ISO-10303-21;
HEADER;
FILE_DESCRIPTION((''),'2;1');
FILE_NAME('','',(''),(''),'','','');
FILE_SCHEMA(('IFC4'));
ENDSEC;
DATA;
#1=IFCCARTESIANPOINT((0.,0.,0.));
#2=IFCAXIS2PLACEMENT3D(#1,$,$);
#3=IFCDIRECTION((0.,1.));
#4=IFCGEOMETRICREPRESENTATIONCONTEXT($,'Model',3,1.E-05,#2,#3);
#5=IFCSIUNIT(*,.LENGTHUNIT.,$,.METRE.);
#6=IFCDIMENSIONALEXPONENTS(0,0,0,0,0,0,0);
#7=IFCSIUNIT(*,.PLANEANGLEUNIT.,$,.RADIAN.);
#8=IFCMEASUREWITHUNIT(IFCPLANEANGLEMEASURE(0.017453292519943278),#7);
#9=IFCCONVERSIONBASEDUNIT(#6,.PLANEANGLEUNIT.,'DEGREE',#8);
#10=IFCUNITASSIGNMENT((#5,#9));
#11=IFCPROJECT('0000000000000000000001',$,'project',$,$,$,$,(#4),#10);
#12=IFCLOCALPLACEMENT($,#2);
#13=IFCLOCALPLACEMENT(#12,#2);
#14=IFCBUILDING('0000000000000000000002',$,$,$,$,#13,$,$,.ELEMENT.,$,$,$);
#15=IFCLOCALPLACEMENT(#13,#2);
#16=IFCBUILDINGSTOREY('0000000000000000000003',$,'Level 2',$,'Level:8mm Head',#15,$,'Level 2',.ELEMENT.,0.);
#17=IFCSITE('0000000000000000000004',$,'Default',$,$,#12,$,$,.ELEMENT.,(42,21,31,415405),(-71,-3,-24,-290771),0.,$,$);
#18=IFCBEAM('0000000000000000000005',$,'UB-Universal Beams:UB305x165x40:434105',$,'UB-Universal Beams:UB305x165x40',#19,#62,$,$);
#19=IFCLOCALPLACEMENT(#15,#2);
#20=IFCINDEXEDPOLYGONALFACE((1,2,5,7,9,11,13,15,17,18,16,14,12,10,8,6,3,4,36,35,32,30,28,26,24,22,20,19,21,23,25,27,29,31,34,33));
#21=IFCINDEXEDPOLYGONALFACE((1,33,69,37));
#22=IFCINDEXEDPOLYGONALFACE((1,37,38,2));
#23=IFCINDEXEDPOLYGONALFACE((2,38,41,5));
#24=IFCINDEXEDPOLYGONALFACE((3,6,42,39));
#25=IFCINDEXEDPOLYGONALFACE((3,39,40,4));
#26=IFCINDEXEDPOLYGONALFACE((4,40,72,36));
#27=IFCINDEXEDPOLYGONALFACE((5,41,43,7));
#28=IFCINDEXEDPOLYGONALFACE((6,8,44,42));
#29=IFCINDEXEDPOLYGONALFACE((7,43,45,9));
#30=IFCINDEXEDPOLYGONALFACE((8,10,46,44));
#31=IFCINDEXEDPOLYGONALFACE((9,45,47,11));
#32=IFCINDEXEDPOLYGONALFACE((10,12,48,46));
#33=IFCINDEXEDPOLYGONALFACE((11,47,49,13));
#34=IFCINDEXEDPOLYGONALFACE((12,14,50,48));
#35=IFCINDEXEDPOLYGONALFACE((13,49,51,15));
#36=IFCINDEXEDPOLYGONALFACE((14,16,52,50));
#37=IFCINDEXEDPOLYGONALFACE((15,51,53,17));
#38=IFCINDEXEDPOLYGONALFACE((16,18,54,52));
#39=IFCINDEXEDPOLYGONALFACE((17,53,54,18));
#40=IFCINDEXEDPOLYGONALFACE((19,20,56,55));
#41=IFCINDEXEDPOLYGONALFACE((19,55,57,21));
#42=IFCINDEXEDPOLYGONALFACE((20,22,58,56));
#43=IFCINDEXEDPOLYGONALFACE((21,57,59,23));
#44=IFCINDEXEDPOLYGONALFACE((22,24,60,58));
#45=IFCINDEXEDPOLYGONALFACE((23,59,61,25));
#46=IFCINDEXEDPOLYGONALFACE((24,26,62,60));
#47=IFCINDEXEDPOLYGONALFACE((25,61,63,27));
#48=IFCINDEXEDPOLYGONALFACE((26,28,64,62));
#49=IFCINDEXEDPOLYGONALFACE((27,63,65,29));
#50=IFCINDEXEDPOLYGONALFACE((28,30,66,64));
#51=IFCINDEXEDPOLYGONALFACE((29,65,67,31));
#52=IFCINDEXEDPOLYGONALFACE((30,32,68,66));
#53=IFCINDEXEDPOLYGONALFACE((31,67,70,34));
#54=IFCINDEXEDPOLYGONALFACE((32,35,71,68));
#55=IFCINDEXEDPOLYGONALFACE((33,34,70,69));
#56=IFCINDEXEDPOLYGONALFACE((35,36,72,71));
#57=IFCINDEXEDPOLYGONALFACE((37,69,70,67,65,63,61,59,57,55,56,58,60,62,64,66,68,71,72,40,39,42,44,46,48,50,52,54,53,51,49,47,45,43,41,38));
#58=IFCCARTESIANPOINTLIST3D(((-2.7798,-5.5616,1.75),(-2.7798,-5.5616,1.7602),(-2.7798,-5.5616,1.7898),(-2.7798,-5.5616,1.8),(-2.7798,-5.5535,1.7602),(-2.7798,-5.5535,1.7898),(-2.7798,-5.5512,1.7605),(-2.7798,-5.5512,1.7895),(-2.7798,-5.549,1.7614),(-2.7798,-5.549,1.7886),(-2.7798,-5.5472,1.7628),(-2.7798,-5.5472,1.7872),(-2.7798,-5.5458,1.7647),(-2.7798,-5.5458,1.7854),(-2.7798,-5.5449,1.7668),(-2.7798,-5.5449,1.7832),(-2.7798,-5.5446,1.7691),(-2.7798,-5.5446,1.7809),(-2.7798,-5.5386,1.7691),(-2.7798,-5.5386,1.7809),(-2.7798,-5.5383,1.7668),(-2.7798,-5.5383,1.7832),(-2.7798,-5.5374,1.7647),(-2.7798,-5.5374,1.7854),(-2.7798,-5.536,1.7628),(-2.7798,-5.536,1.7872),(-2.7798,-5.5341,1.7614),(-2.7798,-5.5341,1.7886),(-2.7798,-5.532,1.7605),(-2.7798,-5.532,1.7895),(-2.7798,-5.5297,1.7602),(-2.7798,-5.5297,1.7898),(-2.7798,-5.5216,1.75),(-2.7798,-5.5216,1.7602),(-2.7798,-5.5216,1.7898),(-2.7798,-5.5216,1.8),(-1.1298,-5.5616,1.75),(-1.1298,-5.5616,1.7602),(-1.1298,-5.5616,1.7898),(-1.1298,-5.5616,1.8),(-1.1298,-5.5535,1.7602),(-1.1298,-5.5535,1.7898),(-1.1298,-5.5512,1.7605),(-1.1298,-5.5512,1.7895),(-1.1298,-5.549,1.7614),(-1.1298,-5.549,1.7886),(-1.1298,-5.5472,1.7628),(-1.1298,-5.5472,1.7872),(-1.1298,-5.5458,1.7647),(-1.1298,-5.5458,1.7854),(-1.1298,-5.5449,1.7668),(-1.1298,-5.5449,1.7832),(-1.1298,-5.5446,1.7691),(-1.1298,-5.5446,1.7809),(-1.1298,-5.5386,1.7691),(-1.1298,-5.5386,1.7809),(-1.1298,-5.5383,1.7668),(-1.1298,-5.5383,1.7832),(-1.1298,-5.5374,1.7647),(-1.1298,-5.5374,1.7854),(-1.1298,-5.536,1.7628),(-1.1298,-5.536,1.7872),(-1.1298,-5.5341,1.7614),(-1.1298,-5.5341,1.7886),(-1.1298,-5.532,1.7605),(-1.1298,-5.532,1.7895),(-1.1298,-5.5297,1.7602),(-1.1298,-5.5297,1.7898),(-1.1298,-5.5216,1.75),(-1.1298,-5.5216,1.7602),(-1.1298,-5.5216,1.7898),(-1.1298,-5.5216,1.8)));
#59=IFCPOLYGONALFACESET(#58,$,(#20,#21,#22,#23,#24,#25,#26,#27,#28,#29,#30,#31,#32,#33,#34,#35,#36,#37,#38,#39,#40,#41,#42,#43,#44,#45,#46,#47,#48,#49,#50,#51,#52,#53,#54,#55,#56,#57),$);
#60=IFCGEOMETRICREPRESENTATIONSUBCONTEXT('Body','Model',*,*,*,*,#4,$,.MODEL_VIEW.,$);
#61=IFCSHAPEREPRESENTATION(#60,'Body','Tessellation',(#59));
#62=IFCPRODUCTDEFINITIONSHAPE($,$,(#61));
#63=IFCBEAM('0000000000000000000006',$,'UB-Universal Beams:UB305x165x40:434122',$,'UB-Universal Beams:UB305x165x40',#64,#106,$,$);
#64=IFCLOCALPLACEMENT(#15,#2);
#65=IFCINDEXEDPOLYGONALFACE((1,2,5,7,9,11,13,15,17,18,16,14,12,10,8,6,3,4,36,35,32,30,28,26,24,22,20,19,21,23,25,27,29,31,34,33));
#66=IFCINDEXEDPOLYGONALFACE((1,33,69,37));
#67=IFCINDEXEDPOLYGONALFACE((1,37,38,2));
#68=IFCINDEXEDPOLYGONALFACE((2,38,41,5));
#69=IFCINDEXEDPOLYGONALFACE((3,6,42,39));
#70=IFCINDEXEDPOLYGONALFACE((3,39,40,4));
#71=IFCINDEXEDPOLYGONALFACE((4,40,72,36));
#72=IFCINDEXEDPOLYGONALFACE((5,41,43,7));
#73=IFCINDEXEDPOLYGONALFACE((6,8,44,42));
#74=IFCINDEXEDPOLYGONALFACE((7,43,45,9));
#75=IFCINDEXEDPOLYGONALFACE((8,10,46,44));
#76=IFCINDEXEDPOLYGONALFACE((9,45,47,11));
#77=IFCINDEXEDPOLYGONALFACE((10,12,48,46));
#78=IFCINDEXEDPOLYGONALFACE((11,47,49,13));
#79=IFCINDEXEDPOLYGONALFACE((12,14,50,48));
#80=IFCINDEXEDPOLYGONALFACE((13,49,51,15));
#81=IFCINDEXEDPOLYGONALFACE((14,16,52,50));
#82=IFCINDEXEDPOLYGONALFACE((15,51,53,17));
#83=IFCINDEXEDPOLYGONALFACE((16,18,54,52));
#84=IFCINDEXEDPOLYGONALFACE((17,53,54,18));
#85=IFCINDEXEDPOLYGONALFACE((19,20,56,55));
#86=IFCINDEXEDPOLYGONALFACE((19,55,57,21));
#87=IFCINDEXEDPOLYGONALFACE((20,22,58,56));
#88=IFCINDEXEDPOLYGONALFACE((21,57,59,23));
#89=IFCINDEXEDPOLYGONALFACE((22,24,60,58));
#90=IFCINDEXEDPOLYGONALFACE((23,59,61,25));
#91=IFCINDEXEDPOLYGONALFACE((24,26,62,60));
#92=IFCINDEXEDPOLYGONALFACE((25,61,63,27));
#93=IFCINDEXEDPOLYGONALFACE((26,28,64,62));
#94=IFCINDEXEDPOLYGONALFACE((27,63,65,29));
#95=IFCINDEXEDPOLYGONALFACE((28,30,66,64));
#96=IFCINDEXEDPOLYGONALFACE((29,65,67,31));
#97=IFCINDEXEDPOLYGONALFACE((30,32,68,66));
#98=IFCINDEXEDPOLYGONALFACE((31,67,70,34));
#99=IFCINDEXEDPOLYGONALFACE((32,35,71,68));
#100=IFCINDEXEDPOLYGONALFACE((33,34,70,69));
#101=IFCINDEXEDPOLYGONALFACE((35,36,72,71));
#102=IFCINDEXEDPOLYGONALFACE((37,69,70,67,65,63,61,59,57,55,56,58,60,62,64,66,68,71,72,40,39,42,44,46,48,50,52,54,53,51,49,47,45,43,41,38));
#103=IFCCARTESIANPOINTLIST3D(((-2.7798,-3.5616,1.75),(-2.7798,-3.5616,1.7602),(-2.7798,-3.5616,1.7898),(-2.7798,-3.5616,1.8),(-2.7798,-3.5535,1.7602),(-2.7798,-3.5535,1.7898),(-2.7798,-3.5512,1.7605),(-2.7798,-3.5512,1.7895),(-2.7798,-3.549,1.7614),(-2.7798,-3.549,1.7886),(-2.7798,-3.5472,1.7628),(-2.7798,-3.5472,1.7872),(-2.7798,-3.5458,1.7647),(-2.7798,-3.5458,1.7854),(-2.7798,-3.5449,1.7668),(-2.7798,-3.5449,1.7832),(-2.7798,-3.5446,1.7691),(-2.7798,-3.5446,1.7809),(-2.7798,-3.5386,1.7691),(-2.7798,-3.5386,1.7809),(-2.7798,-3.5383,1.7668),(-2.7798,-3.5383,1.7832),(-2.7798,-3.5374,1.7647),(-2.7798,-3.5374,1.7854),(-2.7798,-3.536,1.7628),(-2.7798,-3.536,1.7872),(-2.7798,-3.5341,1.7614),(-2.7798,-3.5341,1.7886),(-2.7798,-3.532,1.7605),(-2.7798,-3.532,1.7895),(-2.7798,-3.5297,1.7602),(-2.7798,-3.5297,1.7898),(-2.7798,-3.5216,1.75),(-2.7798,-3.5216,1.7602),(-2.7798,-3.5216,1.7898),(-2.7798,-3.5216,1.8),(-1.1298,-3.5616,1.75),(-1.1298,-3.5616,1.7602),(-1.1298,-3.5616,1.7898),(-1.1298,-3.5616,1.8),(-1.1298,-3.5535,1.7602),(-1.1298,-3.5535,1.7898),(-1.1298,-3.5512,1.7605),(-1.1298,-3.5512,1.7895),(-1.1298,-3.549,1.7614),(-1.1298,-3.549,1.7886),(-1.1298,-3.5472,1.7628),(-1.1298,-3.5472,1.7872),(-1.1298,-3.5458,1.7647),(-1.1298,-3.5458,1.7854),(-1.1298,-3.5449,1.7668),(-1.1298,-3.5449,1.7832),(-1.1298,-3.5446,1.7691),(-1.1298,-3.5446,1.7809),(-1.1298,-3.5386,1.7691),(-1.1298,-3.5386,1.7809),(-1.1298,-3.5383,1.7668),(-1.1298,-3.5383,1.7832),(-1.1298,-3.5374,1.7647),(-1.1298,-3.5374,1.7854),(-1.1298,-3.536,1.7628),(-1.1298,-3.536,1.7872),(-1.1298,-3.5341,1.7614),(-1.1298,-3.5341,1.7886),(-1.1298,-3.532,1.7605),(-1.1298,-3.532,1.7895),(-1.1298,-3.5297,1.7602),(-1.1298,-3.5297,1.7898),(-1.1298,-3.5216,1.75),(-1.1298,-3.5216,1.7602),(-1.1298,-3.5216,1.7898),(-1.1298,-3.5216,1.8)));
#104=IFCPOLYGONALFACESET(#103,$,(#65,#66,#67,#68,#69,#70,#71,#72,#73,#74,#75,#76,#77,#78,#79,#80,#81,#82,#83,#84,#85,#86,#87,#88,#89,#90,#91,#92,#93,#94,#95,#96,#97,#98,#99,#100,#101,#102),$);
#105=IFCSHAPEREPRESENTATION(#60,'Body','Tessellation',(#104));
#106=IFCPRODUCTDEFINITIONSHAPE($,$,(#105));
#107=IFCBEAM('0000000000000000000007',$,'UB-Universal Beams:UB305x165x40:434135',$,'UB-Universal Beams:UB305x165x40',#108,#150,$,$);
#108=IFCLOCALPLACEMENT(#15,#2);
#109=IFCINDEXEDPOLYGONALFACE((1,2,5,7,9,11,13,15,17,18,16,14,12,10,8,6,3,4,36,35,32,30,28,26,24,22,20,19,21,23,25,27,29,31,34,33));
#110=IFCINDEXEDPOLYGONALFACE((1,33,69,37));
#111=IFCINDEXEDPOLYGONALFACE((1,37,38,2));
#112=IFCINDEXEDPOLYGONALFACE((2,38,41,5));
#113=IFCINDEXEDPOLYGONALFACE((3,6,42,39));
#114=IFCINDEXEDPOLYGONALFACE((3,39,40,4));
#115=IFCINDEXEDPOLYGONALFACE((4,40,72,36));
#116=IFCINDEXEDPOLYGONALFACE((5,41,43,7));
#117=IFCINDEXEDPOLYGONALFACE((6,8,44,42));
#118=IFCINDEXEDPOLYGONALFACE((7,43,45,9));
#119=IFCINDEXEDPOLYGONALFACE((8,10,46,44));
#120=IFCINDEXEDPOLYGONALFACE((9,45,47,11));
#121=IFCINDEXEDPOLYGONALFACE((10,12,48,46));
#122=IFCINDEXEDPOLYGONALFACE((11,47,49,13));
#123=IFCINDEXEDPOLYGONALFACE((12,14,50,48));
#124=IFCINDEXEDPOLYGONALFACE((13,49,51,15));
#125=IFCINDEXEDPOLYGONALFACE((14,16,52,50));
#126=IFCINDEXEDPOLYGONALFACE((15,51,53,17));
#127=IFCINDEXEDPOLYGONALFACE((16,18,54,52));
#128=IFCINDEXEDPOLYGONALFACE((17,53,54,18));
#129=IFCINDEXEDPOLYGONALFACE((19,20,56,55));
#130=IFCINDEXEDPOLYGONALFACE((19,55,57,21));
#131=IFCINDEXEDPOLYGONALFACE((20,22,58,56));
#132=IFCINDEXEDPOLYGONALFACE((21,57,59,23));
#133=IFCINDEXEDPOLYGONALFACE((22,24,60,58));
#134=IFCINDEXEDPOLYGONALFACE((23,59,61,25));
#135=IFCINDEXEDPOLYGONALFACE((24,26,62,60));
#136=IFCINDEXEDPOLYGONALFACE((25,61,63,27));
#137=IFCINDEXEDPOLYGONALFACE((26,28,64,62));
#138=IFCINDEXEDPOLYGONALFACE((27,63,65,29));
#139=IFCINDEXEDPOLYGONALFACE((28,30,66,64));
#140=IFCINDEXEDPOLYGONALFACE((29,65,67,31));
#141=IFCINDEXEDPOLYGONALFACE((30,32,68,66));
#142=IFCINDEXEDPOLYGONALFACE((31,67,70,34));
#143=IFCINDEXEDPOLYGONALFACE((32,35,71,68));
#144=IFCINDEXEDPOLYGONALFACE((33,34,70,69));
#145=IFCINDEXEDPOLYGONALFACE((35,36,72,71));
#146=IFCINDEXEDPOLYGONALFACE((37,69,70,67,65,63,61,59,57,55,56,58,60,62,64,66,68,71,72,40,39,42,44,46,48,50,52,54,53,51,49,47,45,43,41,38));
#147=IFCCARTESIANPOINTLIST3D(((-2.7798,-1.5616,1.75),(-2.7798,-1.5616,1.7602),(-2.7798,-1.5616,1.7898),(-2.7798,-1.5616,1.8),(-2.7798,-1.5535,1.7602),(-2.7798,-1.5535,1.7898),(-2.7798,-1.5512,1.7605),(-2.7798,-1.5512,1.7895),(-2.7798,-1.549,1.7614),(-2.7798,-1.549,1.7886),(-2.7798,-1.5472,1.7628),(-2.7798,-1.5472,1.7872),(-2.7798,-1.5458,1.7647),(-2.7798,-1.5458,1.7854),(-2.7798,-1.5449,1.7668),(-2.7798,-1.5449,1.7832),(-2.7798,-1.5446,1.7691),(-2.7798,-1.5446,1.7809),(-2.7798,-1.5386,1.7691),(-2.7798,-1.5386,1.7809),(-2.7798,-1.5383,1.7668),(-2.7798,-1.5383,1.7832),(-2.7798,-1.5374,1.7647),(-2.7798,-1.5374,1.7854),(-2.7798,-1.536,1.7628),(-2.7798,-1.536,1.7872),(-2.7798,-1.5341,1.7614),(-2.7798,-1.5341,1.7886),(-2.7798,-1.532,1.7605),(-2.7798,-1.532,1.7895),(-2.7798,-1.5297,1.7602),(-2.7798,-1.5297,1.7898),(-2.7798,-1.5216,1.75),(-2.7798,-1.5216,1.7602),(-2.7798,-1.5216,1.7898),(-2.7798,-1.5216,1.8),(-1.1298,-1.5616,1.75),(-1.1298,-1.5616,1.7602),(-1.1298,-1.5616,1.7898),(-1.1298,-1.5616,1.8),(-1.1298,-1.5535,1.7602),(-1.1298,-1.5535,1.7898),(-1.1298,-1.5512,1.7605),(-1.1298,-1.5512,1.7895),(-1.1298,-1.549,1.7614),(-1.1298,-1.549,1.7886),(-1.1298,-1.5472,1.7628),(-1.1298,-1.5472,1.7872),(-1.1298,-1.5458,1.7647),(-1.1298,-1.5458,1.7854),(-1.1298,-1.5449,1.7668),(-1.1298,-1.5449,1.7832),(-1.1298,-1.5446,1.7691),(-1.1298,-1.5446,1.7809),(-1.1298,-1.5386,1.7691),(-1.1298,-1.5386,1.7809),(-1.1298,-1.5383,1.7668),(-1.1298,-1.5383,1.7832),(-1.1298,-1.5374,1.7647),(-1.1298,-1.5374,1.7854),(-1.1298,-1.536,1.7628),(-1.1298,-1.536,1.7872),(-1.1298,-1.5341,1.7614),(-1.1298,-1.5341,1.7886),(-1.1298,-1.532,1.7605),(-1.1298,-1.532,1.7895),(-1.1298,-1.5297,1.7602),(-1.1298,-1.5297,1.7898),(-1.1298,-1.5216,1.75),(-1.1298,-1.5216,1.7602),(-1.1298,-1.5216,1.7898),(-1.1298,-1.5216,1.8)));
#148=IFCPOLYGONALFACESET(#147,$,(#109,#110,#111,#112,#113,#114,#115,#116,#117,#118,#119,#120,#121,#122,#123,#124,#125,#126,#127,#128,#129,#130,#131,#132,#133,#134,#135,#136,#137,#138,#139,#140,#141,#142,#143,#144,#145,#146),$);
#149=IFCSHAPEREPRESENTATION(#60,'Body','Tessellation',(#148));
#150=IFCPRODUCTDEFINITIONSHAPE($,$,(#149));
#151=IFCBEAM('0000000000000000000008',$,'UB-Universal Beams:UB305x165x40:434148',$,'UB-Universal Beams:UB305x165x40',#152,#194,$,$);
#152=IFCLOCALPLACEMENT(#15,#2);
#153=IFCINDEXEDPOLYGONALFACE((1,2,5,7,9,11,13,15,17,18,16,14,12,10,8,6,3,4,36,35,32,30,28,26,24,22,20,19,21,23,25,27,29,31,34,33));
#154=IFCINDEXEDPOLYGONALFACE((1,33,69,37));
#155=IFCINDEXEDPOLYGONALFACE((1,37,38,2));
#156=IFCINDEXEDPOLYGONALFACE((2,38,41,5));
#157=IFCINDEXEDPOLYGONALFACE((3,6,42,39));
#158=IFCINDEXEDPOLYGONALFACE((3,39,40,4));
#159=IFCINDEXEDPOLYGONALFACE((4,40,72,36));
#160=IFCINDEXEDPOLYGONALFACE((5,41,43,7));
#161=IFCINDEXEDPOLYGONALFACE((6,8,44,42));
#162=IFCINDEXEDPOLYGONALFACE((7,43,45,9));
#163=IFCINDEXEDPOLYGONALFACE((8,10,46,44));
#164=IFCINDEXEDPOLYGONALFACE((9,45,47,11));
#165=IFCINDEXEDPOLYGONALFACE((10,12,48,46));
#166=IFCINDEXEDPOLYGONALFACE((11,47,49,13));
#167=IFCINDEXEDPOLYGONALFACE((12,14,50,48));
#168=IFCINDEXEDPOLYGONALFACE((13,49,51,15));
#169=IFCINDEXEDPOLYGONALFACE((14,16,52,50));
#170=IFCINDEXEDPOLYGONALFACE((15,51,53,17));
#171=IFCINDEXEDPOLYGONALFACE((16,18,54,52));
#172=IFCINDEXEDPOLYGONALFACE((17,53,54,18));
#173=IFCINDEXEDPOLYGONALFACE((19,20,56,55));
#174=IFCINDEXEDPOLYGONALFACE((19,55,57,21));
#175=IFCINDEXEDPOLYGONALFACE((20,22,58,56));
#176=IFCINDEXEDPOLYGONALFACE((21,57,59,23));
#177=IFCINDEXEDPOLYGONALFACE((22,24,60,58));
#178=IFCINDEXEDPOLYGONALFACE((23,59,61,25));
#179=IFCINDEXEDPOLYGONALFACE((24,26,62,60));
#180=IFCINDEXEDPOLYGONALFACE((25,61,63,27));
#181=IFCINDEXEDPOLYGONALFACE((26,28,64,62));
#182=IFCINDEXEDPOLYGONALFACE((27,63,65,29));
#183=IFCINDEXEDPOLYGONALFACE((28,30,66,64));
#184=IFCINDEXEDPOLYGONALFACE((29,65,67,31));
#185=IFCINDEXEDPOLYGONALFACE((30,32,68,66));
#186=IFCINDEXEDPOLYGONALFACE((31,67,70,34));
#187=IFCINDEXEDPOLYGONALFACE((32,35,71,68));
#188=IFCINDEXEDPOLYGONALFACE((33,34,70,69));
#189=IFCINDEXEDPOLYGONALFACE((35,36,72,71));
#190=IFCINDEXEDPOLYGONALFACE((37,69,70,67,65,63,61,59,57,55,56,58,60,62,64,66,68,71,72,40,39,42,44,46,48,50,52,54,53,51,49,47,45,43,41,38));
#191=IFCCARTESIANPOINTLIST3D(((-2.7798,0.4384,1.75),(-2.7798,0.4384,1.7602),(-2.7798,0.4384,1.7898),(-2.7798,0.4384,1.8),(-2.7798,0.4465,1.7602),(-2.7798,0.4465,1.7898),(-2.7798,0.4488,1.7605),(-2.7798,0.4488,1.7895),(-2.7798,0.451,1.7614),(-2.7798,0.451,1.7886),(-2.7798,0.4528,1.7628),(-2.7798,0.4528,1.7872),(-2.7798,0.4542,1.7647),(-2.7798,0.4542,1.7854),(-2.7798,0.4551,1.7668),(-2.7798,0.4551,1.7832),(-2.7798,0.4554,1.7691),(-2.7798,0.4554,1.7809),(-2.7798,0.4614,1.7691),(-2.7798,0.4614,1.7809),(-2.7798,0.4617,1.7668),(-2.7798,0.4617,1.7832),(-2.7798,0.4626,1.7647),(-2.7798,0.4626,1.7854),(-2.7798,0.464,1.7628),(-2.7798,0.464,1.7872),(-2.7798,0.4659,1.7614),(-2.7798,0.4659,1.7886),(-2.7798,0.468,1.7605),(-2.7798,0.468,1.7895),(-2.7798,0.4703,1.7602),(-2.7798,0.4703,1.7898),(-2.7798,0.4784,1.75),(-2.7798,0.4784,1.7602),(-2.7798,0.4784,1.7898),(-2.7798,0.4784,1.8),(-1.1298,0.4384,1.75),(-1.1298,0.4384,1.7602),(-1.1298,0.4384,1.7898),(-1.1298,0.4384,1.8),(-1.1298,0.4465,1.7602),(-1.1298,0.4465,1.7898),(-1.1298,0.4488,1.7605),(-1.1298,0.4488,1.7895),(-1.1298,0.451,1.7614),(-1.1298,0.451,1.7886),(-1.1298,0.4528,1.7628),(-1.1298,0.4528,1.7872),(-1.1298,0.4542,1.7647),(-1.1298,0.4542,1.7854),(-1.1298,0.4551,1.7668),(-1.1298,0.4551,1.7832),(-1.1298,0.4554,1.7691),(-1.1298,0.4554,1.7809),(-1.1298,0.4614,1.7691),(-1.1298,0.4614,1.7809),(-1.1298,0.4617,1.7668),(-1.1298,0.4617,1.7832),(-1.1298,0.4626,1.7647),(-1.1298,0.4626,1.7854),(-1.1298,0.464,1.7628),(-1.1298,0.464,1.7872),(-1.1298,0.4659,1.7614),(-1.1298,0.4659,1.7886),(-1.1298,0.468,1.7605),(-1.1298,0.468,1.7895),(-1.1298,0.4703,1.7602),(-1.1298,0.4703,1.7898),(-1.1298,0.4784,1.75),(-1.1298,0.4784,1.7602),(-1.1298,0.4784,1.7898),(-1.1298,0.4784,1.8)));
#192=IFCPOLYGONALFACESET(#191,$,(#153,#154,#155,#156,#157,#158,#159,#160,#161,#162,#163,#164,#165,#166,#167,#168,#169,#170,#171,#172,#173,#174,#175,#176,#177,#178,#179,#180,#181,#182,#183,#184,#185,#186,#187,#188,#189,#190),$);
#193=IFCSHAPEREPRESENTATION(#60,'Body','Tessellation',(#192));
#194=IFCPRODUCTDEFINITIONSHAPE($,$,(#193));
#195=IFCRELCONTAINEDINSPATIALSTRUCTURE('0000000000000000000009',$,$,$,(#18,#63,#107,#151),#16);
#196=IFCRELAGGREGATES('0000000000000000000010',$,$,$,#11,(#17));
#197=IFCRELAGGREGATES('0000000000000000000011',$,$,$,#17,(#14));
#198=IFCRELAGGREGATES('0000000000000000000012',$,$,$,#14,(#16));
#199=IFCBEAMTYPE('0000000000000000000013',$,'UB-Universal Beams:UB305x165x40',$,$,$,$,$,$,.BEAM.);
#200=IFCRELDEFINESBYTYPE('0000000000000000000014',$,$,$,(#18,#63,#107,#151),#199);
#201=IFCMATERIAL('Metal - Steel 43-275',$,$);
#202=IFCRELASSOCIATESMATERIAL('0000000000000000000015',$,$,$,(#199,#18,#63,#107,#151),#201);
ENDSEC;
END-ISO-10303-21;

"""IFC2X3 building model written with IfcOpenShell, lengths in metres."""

from ifc_helpers import new_model, entity, si_unit, converted_unit, direction, frame, frame_2d, origin, place, context, subcontext, project, spatial, i_section, extrude, material, type_object, element, save


model = new_model("IFC2X3")

# Units and contexts
model_context = context("Model", 3, precision=1e-05, world=origin(), true_north=direction((0.0, 1.0)))
body_context = subcontext(model_context, "Body", "Model", "MODEL_VIEW")
ifc_project = project(units=[si_unit("LENGTHUNIT", "METRE"), converted_unit("PLANEANGLEUNIT", "DEGREE", entity("IfcPlaneAngleMeasure", 0.017453292519943278), si_unit("PLANEANGLEUNIT", "RADIAN"), dimensions=[0, 0, 0, 0, 0, 0, 0])], contexts=[model_context])

# Site, building, storey
site_placement = place(None, origin())
site = spatial("IfcSite", under=ifc_project, at=site_placement, Name="Default", CompositionType="ELEMENT", RefLatitude=(42, 21, 31, 415405), RefLongitude=(-71, -3, -24, -290771), RefElevation=0.0)
building_placement = place(site_placement, origin())
building = spatial("IfcBuilding", under=site, at=building_placement, CompositionType="ELEMENT")
storey_placement = place(building_placement, origin())
storey = spatial("IfcBuildingStorey", under=building, at=storey_placement, Name="Level 2", ObjectType="Level:8mm Head", LongName="Level 2", CompositionType="ELEMENT", Elevation=0.0)

# Shared definitions
ifc_material_1 = material(Name="Metal - Steel 43-275")

# Beams
beam_type = type_object("IfcBeamType", Name="UB-Universal Beams:UB305x165x40", PredefinedType="BEAM", material=ifc_material_1)
beam_1_placement = place(storey_placement, frame((-2.7798, -5.5416, 1.8)))
element("IfcBeam", 1, at=beam_1_placement, inside=storey, type_object=beam_type, material=ifc_material_1, Name="UB-Universal Beams:UB305x165x40:434105", ObjectType="UB-Universal Beams:UB305x165x40", context=body_context, shape_type="SweptSolid", body=[
    extrude(i_section(OverallWidth=0.04, OverallDepth=0.05, WebThickness=0.006, FlangeThickness=0.0102, FilletRadius=0.0089, at=frame_2d((0.0, 0.0), x_axis=(0.0, 1.0))), frame((0.0, 0.0, -0.025), z_axis=(1.0, 0.0, 0.0), x_axis=(0.0, 0.0, -1.0)), (0.0, 0.0, 1.0), 1.65),
])
beam_2_placement = place(storey_placement, frame((-2.7798, -3.5416, 1.8)))
element("IfcBeam", 2, at=beam_2_placement, inside=storey, type_object=beam_type, material=ifc_material_1, Name="UB-Universal Beams:UB305x165x40:434122", ObjectType="UB-Universal Beams:UB305x165x40", context=body_context, shape_type="SweptSolid", body=[
    extrude(i_section(OverallWidth=0.04, OverallDepth=0.05, WebThickness=0.006, FlangeThickness=0.0102, FilletRadius=0.0089, at=frame_2d((0.0, 0.0), x_axis=(0.0, 1.0))), frame((0.0, 0.0, -0.025), z_axis=(1.0, 0.0, 0.0), x_axis=(0.0, 0.0, -1.0)), (0.0, 0.0, 1.0), 1.65),
])
beam_3_placement = place(storey_placement, frame((-2.7798, -1.5416, 1.8)))
element("IfcBeam", 3, at=beam_3_placement, inside=storey, type_object=beam_type, material=ifc_material_1, Name="UB-Universal Beams:UB305x165x40:434135", ObjectType="UB-Universal Beams:UB305x165x40", context=body_context, shape_type="SweptSolid", body=[
    extrude(i_section(OverallWidth=0.04, OverallDepth=0.05, WebThickness=0.006, FlangeThickness=0.0102, FilletRadius=0.0089, at=frame_2d((0.0, 0.0), x_axis=(0.0, 1.0))), frame((0.0, 0.0, -0.025), z_axis=(1.0, 0.0, 0.0), x_axis=(0.0, 0.0, -1.0)), (0.0, 0.0, 1.0), 1.65),
])
beam_4_placement = place(storey_placement, frame((-2.7798, 0.4584, 1.8)))
element("IfcBeam", 4, at=beam_4_placement, inside=storey, type_object=beam_type, material=ifc_material_1, Name="UB-Universal Beams:UB305x165x40:434148", ObjectType="UB-Universal Beams:UB305x165x40", context=body_context, shape_type="SweptSolid", body=[
    extrude(i_section(OverallWidth=0.04, OverallDepth=0.05, WebThickness=0.006, FlangeThickness=0.0102, FilletRadius=0.0089, at=frame_2d((0.0, 0.0), x_axis=(0.0, 1.0))), frame((0.0, 0.0, -0.025), z_axis=(1.0, 0.0, 0.0), x_axis=(0.0, 0.0, -1.0)), (0.0, 0.0, 1.0), 1.65),
])

save(model, "model.ifc")
